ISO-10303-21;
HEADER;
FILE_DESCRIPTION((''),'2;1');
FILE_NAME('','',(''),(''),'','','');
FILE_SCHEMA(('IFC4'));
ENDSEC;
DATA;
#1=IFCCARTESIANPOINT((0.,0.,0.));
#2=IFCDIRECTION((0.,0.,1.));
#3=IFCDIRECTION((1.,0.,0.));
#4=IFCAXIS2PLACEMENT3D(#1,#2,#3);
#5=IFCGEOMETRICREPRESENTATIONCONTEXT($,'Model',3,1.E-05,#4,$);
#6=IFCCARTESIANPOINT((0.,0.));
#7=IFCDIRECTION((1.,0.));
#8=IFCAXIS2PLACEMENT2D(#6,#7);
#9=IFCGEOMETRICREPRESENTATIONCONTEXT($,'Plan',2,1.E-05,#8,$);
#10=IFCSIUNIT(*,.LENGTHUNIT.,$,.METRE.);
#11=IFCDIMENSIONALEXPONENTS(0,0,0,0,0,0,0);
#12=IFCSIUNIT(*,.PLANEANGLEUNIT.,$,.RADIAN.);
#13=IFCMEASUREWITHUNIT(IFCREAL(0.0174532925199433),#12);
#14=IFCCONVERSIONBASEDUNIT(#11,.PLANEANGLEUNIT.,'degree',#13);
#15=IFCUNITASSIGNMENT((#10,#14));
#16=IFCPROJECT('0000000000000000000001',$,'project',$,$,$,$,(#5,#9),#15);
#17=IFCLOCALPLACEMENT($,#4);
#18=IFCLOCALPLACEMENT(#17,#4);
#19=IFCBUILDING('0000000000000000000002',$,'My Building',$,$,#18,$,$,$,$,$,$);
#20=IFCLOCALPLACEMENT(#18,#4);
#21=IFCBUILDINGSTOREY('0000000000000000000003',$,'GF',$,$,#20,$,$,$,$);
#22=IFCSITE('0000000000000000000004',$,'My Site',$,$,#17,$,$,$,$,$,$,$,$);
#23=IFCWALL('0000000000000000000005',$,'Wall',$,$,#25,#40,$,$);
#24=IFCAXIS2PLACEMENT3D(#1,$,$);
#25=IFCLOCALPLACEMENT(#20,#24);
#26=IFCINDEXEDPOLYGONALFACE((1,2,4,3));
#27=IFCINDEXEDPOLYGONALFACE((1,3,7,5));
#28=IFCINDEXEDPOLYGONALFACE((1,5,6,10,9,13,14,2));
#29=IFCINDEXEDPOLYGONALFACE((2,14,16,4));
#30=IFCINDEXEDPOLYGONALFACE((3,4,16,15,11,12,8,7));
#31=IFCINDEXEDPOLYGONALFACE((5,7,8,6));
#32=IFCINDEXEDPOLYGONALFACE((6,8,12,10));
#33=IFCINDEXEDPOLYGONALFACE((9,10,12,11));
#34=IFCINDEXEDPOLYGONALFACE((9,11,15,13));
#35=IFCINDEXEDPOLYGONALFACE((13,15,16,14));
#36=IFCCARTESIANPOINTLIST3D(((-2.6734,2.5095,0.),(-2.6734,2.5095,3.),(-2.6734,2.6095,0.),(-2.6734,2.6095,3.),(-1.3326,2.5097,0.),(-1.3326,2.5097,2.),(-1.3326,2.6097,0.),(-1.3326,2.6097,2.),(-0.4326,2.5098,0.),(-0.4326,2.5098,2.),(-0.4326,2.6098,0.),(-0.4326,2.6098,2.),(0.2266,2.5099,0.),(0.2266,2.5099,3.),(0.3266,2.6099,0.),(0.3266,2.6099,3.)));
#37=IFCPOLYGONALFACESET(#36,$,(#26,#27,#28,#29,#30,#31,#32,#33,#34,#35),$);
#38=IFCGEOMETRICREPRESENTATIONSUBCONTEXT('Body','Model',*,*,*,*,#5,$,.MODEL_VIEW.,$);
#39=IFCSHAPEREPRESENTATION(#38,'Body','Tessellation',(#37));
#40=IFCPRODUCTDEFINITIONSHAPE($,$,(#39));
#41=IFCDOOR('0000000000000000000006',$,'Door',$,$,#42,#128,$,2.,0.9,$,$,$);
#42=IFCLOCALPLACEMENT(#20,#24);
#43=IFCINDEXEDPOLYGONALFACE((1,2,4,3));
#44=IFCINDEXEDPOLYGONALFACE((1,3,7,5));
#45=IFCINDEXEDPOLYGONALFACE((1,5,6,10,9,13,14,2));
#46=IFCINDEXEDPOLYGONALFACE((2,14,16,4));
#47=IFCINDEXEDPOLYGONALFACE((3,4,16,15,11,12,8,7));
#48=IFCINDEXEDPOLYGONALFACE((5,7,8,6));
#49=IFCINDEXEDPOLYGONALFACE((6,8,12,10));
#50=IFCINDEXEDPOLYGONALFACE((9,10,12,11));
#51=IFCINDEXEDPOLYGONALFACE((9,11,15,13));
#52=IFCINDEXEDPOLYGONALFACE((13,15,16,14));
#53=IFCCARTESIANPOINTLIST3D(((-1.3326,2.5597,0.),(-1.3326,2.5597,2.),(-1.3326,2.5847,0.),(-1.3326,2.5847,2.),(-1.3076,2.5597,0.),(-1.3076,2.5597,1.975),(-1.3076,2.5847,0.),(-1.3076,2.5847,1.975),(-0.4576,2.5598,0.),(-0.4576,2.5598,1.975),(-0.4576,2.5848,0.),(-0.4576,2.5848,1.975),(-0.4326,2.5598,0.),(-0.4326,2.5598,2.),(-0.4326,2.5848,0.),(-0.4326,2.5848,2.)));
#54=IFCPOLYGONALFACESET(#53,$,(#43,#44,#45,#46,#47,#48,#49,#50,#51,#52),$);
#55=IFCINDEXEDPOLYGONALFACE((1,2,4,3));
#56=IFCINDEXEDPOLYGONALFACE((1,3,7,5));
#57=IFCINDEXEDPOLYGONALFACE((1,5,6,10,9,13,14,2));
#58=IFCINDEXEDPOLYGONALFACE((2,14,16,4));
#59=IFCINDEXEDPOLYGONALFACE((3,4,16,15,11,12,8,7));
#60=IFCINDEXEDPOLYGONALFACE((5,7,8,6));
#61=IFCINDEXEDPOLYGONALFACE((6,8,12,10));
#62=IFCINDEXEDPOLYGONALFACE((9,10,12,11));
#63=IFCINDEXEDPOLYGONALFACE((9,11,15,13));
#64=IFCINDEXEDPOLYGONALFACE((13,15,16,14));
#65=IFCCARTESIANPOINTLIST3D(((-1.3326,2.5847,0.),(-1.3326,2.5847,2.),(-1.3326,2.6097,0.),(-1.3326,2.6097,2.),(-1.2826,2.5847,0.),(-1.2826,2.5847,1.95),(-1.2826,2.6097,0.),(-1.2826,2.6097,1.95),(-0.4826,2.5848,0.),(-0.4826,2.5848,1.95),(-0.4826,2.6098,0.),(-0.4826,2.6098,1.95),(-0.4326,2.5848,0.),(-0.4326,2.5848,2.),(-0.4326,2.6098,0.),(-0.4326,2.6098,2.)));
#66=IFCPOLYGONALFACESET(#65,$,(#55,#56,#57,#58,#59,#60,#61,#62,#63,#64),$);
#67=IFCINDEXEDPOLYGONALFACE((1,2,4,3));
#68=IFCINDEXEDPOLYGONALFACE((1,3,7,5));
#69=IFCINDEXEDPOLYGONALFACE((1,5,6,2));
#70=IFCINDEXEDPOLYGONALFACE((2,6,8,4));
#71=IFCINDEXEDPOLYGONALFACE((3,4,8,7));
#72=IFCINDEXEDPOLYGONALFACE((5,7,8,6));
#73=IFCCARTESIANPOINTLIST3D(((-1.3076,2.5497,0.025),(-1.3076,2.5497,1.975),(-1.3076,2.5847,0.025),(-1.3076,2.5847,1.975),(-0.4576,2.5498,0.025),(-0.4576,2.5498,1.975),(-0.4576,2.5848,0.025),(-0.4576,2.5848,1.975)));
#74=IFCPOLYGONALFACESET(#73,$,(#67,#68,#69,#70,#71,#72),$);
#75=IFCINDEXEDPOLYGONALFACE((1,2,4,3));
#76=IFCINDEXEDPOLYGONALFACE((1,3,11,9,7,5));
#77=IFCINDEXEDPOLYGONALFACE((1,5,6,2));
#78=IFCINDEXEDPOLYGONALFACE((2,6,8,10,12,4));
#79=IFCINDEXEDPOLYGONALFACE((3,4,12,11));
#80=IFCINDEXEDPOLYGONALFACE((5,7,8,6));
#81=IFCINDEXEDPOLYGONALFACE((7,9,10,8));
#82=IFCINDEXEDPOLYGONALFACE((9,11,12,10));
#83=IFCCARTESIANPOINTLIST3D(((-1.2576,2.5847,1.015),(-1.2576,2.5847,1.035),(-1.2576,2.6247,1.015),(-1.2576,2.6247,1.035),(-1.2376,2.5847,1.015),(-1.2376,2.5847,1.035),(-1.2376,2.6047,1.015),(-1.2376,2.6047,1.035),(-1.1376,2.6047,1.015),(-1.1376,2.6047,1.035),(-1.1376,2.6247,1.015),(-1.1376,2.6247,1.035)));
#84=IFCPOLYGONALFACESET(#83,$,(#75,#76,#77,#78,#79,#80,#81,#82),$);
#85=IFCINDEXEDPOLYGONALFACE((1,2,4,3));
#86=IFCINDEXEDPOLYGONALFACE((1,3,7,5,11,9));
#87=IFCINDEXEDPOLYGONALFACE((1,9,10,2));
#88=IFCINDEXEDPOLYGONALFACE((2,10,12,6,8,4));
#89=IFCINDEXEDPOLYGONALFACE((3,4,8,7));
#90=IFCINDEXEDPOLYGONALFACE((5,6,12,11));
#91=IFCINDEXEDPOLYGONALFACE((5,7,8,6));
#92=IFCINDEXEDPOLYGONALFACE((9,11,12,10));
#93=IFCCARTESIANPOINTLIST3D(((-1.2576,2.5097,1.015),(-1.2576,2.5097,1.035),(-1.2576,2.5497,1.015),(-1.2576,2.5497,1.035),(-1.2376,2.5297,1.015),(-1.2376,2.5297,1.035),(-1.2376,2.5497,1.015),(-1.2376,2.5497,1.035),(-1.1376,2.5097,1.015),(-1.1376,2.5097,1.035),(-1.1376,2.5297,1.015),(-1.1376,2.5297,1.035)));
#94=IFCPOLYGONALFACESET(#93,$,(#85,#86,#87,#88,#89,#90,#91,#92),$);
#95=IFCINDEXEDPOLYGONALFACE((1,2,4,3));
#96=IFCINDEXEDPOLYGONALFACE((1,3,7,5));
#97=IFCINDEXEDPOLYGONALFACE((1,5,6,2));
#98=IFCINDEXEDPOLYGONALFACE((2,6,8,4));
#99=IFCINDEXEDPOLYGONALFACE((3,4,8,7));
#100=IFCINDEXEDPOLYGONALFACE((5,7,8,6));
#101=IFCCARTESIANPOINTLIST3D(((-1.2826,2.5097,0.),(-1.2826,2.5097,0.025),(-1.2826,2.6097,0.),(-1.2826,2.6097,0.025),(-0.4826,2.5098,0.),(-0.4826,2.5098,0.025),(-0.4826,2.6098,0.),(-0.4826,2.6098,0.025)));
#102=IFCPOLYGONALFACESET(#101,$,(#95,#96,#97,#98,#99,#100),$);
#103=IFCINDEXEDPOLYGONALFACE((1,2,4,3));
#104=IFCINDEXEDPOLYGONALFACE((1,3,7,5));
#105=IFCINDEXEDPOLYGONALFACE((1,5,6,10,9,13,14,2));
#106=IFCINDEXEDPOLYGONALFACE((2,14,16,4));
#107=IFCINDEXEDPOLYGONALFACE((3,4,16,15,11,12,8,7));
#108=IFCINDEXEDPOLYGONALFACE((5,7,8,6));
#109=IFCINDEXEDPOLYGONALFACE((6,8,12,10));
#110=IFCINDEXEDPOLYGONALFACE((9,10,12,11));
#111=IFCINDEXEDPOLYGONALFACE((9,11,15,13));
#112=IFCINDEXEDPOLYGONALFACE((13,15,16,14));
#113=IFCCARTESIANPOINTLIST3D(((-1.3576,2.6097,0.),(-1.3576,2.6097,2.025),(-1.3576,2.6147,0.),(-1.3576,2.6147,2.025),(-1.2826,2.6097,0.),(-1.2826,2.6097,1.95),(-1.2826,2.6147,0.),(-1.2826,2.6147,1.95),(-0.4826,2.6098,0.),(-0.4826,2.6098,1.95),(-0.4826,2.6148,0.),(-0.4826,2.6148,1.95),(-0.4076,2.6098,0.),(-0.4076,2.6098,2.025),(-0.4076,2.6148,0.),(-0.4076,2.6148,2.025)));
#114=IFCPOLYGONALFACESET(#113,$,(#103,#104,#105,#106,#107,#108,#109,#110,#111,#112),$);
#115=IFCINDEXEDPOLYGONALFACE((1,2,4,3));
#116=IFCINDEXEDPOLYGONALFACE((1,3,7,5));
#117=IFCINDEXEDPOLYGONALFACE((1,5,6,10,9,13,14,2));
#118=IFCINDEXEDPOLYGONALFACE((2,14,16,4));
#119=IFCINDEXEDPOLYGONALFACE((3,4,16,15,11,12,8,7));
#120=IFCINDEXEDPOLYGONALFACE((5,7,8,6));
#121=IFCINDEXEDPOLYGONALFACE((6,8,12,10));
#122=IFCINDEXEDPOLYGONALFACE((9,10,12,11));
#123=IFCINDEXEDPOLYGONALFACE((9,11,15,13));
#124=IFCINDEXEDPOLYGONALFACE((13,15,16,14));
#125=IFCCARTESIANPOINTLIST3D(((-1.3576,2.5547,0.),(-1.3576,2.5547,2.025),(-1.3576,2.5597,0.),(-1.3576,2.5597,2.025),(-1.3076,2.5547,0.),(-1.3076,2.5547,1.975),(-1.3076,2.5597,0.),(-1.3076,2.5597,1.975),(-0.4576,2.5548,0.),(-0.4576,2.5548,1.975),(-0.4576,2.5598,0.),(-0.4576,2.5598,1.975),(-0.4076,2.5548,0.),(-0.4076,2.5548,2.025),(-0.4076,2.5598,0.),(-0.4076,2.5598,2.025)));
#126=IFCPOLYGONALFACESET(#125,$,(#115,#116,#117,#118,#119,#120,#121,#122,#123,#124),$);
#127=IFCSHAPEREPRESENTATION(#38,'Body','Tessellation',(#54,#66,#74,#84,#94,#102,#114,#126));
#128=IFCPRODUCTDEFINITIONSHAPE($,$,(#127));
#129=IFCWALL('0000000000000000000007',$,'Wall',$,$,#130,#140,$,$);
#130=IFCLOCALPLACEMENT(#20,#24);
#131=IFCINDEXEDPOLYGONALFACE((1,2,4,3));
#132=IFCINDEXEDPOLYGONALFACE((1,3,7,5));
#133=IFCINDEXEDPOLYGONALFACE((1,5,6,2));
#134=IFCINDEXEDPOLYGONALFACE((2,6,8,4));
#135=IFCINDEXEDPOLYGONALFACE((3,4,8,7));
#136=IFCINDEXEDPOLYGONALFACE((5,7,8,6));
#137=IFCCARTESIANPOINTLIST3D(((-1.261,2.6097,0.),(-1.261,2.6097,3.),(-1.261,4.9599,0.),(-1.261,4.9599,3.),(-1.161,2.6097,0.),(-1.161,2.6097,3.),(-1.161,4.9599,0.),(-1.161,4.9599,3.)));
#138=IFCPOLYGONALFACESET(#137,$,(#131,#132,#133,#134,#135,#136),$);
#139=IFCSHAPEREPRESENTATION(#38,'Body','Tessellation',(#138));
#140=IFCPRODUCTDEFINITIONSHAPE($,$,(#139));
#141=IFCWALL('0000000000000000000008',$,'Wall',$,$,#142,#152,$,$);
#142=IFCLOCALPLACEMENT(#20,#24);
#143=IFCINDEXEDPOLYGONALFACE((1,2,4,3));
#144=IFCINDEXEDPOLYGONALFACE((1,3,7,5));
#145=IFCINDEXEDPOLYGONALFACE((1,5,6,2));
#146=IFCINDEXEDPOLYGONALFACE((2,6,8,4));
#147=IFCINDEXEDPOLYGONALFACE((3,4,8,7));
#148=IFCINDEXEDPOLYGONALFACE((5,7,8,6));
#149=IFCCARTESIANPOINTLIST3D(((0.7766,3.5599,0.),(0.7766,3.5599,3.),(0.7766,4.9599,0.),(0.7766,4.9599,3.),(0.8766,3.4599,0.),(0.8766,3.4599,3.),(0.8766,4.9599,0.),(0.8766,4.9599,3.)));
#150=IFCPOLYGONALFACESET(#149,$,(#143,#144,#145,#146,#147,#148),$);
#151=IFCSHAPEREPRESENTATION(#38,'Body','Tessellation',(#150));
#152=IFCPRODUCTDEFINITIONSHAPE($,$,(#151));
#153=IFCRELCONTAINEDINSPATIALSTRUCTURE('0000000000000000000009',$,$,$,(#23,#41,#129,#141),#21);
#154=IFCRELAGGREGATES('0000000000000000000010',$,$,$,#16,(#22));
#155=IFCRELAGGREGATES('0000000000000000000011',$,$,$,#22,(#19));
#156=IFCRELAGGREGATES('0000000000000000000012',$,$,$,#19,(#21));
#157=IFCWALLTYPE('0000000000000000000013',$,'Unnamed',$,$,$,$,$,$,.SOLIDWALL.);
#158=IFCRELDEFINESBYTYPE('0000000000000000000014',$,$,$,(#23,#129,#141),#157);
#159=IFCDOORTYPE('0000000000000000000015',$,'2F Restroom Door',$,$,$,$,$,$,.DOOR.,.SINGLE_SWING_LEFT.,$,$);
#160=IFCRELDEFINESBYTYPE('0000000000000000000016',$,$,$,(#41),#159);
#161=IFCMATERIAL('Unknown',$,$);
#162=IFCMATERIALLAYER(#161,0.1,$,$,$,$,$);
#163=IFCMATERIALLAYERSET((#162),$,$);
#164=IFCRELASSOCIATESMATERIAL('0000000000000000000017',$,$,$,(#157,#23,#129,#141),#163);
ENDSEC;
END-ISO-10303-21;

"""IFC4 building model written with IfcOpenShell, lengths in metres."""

from ifc_helpers import new_model, entity, si_unit, converted_unit, frame, origin_with_axes, origin_2d_with_axis, place, context, subcontext, project, spatial, line, indexed_curve, outline, extrude, shape, source, transform, mapped, material, layer, layer_set, layer_usage, type_object, type_shapes, element, fill, save


model = new_model("IFC4")

# Units and contexts
model_context = context("Model", 3, precision=1e-05, world=origin_with_axes())
plan_context = context("Plan", 2, precision=1e-05, world=origin_2d_with_axis())
body_context_1 = subcontext(model_context, "Body", "Model", "MODEL_VIEW")
body_context_2 = subcontext(plan_context, "Body", "Plan", "PLAN_VIEW")
ifc_project = project(units=[si_unit("LENGTHUNIT", "METRE"), converted_unit("PLANEANGLEUNIT", "degree", entity("IfcReal", 0.0174532925199433), si_unit("PLANEANGLEUNIT", "RADIAN"), dimensions=[0, 0, 0, 0, 0, 0, 0])], contexts=[model_context, plan_context])

# Site, building, storey
site_placement = place(None, origin_with_axes())
site = spatial("IfcSite", under=ifc_project, at=site_placement, Name="My Site")
building_placement = place(site_placement, origin_with_axes())
building = spatial("IfcBuilding", under=site, at=building_placement, Name="My Building")
storey_placement = place(building_placement, origin_with_axes())
storey = spatial("IfcBuildingStorey", under=building, at=storey_placement, Name="GF")

# Shared definitions
ifc_material_1 = material(Name="Unknown")

# Shared definitions
ifc_layer_1 = layer(ifc_material_1, 0.1)
ifc_layer_set_1 = layer_set([ifc_layer_1])
wall_type = type_object("IfcWallType", Name="Unnamed", PredefinedType="SOLIDWALL", material=ifc_layer_set_1)

# Wall, opening, door
ifc_layer_usage_1 = layer_usage(ifc_layer_set_1, "AXIS2", "POSITIVE", 0.0)
wall_1_placement = place(storey_placement, frame((0.3266, 2.6099, 0.0), z_axis=(0.0, 0.0, 1.0), x_axis=(-1.0, -0.00012, 0.0)))
wall_1 = element("IfcWall", 1, at=wall_1_placement, inside=storey, type_object=wall_type, material=ifc_layer_usage_1, Name="Wall", context=body_context_1, shape_type="SweptSolid", body=[
    extrude(outline(indexed_curve([(0.0, 0.0), (0.1, 0.1), (3.0, 0.1), (3.0, 0.0)], segments=[line(1, 2, 3, 4, 1)])), origin_with_axes(), (0.0, 0.0, 1.0), 3.0),
])
shared_shape_1 = source(origin_with_axes(), body_context_1, "Body", "SweptSolid", [
    extrude(outline(indexed_curve([(0.0, 0.0), (0.9, 0.0), (0.9, 2.0), (0.0, 2.0)], segments=[line(1, 2, 3, 4, 1)])), frame((0.0, -0.6, 0.0), z_axis=(0.0, -1.0, 0.0), x_axis=(1.0, 0.0, 0.0)), (0.0, 0.0, -1.0), 1.2),
])
opening_1_placement = place(wall_1_placement, frame((0.7592, 0.0, 0.0), z_axis=(0.0, 0.0, 1.0), x_axis=(1.0, 0.0, 0.0)))
opening_1 = element("IfcOpeningElement", 2, at=opening_1_placement, cuts=wall_1, PredefinedType="OPENING", context=body_context_1, shape_type="MappedRepresentation", body=[
    mapped(shared_shape_1, transform((0.0, 0.0, 0.0), x_axis=(1.0, 0.0, 0.0), y_axis=(0.0, 1.0, 0.0), z_axis=(0.0, 0.0, 1.0), scale=1.0)),
])
door_type_1 = type_object("IfcDoorType", Name="2F Restroom Door", OperationType="SINGLE_SWING_LEFT", PredefinedType="DOOR")
shared_shape_2 = source(origin_with_axes(), body_context_1, "Body", "SweptSolid", [
    extrude(outline(indexed_curve([(0.0, 0.0), (0.0, 2.0), (0.9, 2.0), (0.9, 0.0), (0.875, 0.0), (0.875, 1.975), (0.025, 1.975), (0.025, 0.0)], segments=[line(1, 2, 3, 4, 5, 6, 7, 8, 1)])), frame((0.0, 0.025, 0.0), z_axis=(0.0, -1.0, 0.0), x_axis=(1.0, 0.0, 0.0)), (0.0, 0.0, -1.0), 0.025),
    extrude(outline(indexed_curve([(0.0, 0.0), (0.0, 2.0), (0.9, 2.0), (0.9, 0.0), (0.85, 0.0), (0.85, 1.95), (0.05, 1.95), (0.05, 0.0)], segments=[line(1, 2, 3, 4, 5, 6, 7, 8, 1)])), frame((0.0, 0.0, 0.0), z_axis=(0.0, -1.0, 0.0), x_axis=(1.0, 0.0, 0.0)), (0.0, 0.0, -1.0), 0.025),
    extrude(outline(indexed_curve([(0.0, 0.0), (0.85, 0.0), (0.85, 0.035), (0.0, 0.035)], segments=[line(1, 2, 3, 4, 1)])), frame((0.025, 0.025, 0.025), z_axis=(0.0, 0.0, 1.0), x_axis=(1.0, 0.0, 0.0)), (0.0, 0.0, 1.0), 1.95),
    extrude(outline(indexed_curve([(0.0, 0.0), (0.0, -0.04), (-0.12, -0.04), (-0.12, -0.02), (-0.02, -0.02), (-0.02, 0.0)], segments=[line(1, 2, 3, 4, 5, 6, 1)])), frame((0.825, 0.025, 1.015), z_axis=(0.0, 0.0, 1.0), x_axis=(1.0, 0.0, 0.0)), (0.0, 0.0, 1.0), 0.02),
    extrude(outline(indexed_curve([(0.0, 0.0), (0.0, 0.04), (-0.12, 0.04), (-0.12, 0.02), (-0.02, 0.02), (-0.02, 0.0)], segments=[line(1, 2, 3, 4, 5, 6, 1)])), frame((0.825, 0.06, 1.015), z_axis=(0.0, 0.0, 1.0), x_axis=(1.0, 0.0, 0.0)), (0.0, 0.0, 1.0), 0.02),
    extrude(outline(indexed_curve([(0.0, 0.0), (0.8, 0.0), (0.8, 0.1), (0.0, 0.1)], segments=[line(1, 2, 3, 4, 1)])), frame((0.05, 0.0, 0.0), z_axis=(0.0, 0.0, 1.0), x_axis=(1.0, 0.0, 0.0)), (0.0, 0.0, 1.0), 0.025),
    extrude(outline(indexed_curve([(0.0, 0.0), (0.0, 2.025), (0.95, 2.025), (0.95, 0.0), (0.875, 0.0), (0.875, 1.95), (0.075, 1.95), (0.075, 0.0)], segments=[line(1, 2, 3, 4, 5, 6, 7, 8, 1)])), frame((-0.025, -0.005, 0.0), z_axis=(0.0, -1.0, 0.0), x_axis=(1.0, 0.0, 0.0)), (0.0, 0.0, -1.0), 0.005),
    extrude(outline(indexed_curve([(0.0, 0.0), (0.0, 2.025), (0.95, 2.025), (0.95, 0.0), (0.9, 0.0), (0.9, 1.975), (0.05, 1.975), (0.05, 0.0)], segments=[line(1, 2, 3, 4, 5, 6, 7, 8, 1)])), frame((-0.025, 0.05, 0.0), z_axis=(0.0, -1.0, 0.0), x_axis=(1.0, 0.0, 0.0)), (0.0, 0.0, -1.0), 0.005),
])
shared_shape_3 = source(origin_with_axes(), body_context_2, "Body", "Curve2D", [
    entity("IfcIndexedPolyCurve", entity("IfcCartesianPointList2D", [[0.0, 0.0], [0.0, 0.05], [0.025, 0.05], [0.025, 0.025], [0.05, 0.025], [0.05, 0.0]]), [entity("IfcLineIndex", [1, 2, 3, 4, 5, 6, 1])]),
    entity("IfcIndexedPolyCurve", entity("IfcCartesianPointList2D", [[0.9, 0.0], [0.9, 0.05], [0.875, 0.05], [0.875, 0.025], [0.85, 0.025], [0.85, 0.0]]), [entity("IfcLineIndex", [1, 2, 3, 4, 5, 6, 1])]),
    entity("IfcTrimmedCurve", entity("IfcEllipse", entity("IfcAxis2Placement2D", entity("IfcCartesianPoint", [0.06, 0.05]), entity("IfcDirection", [1.0, 0.0])), 0.815, 0.85), [entity("IfcCartesianPoint", [0.875, 0.05])], [entity("IfcCartesianPoint", [0.06, 0.9])], True, "CARTESIAN"),
    entity("IfcIndexedPolyCurve", entity("IfcCartesianPointList2D", [[0.025, 0.05], [0.06, 0.05], [0.06, 0.9], [0.025, 0.9]]), [entity("IfcLineIndex", [1, 2, 3, 4, 1])]),
])
type_shapes(door_type_1, [shared_shape_2, shared_shape_3])
door_1_placement = place(opening_1_placement, frame((0.0, 0.0, 0.0), z_axis=(0.0, 0.0, 1.0), x_axis=(1.0, 0.0, 0.0)))
door_1 = element("IfcDoor", 3, at=door_1_placement, inside=storey, type_object=door_type_1, Name="Door", OverallHeight=2.0, OverallWidth=0.9, shapes=[
    shape(body_context_1, "Body", "MappedRepresentation", [mapped(shared_shape_2, transform((0.0, 0.0, 0.0), x_axis=(1.0, 0.0, 0.0), y_axis=(0.0, 1.0, 0.0), z_axis=(0.0, 0.0, 1.0), scale=1.0))]),
    shape(body_context_2, "Body", "MappedRepresentation", [mapped(shared_shape_3, transform((0.0, 0.0, 0.0), x_axis=(1.0, 0.0, 0.0), y_axis=(0.0, 1.0, 0.0), z_axis=(0.0, 0.0, 1.0), scale=1.0))]),
])
fill(opening_1, door_1)

# Walls
ifc_layer_usage_2 = layer_usage(ifc_layer_set_1, "AXIS2", "POSITIVE", 0.0)
wall_2_placement = place(storey_placement, frame((-1.261, 4.9599, 0.0), z_axis=(0.0, 0.0, 1.0), x_axis=(0.000037, -1.0, 0.0)))
element("IfcWall", 4, at=wall_2_placement, inside=storey, type_object=wall_type, material=ifc_layer_usage_2, Name="Wall", context=body_context_1, shape_type="SweptSolid", body=[
    extrude(outline(indexed_curve([(0.0, 0.0), (0.0, 0.1), (2.3502, 0.1), (2.3502, 0.0)], segments=[line(1, 2, 3, 4, 1)])), origin_with_axes(), (0.0, 0.0, 1.0), 3.0),
])
ifc_layer_usage_3 = layer_usage(ifc_layer_set_1, "AXIS2", "POSITIVE", 0.0)
wall_3_placement = place(storey_placement, frame((0.7766, 4.9599, 0.0), z_axis=(0.0, 0.0, 1.0), x_axis=(0.0, -1.0, 0.0)))
element("IfcWall", 5, at=wall_3_placement, inside=storey, type_object=wall_type, material=ifc_layer_usage_3, Name="Wall", context=body_context_1, shape_type="SweptSolid", body=[
    extrude(outline(indexed_curve([(0.0, 0.0), (0.0, 0.1), (1.5, 0.1), (1.4, 0.0)], segments=[line(1, 2, 3, 4, 1)])), origin_with_axes(), (0.0, 0.0, 1.0), 3.0),
])

save(model, "model.ifc")
